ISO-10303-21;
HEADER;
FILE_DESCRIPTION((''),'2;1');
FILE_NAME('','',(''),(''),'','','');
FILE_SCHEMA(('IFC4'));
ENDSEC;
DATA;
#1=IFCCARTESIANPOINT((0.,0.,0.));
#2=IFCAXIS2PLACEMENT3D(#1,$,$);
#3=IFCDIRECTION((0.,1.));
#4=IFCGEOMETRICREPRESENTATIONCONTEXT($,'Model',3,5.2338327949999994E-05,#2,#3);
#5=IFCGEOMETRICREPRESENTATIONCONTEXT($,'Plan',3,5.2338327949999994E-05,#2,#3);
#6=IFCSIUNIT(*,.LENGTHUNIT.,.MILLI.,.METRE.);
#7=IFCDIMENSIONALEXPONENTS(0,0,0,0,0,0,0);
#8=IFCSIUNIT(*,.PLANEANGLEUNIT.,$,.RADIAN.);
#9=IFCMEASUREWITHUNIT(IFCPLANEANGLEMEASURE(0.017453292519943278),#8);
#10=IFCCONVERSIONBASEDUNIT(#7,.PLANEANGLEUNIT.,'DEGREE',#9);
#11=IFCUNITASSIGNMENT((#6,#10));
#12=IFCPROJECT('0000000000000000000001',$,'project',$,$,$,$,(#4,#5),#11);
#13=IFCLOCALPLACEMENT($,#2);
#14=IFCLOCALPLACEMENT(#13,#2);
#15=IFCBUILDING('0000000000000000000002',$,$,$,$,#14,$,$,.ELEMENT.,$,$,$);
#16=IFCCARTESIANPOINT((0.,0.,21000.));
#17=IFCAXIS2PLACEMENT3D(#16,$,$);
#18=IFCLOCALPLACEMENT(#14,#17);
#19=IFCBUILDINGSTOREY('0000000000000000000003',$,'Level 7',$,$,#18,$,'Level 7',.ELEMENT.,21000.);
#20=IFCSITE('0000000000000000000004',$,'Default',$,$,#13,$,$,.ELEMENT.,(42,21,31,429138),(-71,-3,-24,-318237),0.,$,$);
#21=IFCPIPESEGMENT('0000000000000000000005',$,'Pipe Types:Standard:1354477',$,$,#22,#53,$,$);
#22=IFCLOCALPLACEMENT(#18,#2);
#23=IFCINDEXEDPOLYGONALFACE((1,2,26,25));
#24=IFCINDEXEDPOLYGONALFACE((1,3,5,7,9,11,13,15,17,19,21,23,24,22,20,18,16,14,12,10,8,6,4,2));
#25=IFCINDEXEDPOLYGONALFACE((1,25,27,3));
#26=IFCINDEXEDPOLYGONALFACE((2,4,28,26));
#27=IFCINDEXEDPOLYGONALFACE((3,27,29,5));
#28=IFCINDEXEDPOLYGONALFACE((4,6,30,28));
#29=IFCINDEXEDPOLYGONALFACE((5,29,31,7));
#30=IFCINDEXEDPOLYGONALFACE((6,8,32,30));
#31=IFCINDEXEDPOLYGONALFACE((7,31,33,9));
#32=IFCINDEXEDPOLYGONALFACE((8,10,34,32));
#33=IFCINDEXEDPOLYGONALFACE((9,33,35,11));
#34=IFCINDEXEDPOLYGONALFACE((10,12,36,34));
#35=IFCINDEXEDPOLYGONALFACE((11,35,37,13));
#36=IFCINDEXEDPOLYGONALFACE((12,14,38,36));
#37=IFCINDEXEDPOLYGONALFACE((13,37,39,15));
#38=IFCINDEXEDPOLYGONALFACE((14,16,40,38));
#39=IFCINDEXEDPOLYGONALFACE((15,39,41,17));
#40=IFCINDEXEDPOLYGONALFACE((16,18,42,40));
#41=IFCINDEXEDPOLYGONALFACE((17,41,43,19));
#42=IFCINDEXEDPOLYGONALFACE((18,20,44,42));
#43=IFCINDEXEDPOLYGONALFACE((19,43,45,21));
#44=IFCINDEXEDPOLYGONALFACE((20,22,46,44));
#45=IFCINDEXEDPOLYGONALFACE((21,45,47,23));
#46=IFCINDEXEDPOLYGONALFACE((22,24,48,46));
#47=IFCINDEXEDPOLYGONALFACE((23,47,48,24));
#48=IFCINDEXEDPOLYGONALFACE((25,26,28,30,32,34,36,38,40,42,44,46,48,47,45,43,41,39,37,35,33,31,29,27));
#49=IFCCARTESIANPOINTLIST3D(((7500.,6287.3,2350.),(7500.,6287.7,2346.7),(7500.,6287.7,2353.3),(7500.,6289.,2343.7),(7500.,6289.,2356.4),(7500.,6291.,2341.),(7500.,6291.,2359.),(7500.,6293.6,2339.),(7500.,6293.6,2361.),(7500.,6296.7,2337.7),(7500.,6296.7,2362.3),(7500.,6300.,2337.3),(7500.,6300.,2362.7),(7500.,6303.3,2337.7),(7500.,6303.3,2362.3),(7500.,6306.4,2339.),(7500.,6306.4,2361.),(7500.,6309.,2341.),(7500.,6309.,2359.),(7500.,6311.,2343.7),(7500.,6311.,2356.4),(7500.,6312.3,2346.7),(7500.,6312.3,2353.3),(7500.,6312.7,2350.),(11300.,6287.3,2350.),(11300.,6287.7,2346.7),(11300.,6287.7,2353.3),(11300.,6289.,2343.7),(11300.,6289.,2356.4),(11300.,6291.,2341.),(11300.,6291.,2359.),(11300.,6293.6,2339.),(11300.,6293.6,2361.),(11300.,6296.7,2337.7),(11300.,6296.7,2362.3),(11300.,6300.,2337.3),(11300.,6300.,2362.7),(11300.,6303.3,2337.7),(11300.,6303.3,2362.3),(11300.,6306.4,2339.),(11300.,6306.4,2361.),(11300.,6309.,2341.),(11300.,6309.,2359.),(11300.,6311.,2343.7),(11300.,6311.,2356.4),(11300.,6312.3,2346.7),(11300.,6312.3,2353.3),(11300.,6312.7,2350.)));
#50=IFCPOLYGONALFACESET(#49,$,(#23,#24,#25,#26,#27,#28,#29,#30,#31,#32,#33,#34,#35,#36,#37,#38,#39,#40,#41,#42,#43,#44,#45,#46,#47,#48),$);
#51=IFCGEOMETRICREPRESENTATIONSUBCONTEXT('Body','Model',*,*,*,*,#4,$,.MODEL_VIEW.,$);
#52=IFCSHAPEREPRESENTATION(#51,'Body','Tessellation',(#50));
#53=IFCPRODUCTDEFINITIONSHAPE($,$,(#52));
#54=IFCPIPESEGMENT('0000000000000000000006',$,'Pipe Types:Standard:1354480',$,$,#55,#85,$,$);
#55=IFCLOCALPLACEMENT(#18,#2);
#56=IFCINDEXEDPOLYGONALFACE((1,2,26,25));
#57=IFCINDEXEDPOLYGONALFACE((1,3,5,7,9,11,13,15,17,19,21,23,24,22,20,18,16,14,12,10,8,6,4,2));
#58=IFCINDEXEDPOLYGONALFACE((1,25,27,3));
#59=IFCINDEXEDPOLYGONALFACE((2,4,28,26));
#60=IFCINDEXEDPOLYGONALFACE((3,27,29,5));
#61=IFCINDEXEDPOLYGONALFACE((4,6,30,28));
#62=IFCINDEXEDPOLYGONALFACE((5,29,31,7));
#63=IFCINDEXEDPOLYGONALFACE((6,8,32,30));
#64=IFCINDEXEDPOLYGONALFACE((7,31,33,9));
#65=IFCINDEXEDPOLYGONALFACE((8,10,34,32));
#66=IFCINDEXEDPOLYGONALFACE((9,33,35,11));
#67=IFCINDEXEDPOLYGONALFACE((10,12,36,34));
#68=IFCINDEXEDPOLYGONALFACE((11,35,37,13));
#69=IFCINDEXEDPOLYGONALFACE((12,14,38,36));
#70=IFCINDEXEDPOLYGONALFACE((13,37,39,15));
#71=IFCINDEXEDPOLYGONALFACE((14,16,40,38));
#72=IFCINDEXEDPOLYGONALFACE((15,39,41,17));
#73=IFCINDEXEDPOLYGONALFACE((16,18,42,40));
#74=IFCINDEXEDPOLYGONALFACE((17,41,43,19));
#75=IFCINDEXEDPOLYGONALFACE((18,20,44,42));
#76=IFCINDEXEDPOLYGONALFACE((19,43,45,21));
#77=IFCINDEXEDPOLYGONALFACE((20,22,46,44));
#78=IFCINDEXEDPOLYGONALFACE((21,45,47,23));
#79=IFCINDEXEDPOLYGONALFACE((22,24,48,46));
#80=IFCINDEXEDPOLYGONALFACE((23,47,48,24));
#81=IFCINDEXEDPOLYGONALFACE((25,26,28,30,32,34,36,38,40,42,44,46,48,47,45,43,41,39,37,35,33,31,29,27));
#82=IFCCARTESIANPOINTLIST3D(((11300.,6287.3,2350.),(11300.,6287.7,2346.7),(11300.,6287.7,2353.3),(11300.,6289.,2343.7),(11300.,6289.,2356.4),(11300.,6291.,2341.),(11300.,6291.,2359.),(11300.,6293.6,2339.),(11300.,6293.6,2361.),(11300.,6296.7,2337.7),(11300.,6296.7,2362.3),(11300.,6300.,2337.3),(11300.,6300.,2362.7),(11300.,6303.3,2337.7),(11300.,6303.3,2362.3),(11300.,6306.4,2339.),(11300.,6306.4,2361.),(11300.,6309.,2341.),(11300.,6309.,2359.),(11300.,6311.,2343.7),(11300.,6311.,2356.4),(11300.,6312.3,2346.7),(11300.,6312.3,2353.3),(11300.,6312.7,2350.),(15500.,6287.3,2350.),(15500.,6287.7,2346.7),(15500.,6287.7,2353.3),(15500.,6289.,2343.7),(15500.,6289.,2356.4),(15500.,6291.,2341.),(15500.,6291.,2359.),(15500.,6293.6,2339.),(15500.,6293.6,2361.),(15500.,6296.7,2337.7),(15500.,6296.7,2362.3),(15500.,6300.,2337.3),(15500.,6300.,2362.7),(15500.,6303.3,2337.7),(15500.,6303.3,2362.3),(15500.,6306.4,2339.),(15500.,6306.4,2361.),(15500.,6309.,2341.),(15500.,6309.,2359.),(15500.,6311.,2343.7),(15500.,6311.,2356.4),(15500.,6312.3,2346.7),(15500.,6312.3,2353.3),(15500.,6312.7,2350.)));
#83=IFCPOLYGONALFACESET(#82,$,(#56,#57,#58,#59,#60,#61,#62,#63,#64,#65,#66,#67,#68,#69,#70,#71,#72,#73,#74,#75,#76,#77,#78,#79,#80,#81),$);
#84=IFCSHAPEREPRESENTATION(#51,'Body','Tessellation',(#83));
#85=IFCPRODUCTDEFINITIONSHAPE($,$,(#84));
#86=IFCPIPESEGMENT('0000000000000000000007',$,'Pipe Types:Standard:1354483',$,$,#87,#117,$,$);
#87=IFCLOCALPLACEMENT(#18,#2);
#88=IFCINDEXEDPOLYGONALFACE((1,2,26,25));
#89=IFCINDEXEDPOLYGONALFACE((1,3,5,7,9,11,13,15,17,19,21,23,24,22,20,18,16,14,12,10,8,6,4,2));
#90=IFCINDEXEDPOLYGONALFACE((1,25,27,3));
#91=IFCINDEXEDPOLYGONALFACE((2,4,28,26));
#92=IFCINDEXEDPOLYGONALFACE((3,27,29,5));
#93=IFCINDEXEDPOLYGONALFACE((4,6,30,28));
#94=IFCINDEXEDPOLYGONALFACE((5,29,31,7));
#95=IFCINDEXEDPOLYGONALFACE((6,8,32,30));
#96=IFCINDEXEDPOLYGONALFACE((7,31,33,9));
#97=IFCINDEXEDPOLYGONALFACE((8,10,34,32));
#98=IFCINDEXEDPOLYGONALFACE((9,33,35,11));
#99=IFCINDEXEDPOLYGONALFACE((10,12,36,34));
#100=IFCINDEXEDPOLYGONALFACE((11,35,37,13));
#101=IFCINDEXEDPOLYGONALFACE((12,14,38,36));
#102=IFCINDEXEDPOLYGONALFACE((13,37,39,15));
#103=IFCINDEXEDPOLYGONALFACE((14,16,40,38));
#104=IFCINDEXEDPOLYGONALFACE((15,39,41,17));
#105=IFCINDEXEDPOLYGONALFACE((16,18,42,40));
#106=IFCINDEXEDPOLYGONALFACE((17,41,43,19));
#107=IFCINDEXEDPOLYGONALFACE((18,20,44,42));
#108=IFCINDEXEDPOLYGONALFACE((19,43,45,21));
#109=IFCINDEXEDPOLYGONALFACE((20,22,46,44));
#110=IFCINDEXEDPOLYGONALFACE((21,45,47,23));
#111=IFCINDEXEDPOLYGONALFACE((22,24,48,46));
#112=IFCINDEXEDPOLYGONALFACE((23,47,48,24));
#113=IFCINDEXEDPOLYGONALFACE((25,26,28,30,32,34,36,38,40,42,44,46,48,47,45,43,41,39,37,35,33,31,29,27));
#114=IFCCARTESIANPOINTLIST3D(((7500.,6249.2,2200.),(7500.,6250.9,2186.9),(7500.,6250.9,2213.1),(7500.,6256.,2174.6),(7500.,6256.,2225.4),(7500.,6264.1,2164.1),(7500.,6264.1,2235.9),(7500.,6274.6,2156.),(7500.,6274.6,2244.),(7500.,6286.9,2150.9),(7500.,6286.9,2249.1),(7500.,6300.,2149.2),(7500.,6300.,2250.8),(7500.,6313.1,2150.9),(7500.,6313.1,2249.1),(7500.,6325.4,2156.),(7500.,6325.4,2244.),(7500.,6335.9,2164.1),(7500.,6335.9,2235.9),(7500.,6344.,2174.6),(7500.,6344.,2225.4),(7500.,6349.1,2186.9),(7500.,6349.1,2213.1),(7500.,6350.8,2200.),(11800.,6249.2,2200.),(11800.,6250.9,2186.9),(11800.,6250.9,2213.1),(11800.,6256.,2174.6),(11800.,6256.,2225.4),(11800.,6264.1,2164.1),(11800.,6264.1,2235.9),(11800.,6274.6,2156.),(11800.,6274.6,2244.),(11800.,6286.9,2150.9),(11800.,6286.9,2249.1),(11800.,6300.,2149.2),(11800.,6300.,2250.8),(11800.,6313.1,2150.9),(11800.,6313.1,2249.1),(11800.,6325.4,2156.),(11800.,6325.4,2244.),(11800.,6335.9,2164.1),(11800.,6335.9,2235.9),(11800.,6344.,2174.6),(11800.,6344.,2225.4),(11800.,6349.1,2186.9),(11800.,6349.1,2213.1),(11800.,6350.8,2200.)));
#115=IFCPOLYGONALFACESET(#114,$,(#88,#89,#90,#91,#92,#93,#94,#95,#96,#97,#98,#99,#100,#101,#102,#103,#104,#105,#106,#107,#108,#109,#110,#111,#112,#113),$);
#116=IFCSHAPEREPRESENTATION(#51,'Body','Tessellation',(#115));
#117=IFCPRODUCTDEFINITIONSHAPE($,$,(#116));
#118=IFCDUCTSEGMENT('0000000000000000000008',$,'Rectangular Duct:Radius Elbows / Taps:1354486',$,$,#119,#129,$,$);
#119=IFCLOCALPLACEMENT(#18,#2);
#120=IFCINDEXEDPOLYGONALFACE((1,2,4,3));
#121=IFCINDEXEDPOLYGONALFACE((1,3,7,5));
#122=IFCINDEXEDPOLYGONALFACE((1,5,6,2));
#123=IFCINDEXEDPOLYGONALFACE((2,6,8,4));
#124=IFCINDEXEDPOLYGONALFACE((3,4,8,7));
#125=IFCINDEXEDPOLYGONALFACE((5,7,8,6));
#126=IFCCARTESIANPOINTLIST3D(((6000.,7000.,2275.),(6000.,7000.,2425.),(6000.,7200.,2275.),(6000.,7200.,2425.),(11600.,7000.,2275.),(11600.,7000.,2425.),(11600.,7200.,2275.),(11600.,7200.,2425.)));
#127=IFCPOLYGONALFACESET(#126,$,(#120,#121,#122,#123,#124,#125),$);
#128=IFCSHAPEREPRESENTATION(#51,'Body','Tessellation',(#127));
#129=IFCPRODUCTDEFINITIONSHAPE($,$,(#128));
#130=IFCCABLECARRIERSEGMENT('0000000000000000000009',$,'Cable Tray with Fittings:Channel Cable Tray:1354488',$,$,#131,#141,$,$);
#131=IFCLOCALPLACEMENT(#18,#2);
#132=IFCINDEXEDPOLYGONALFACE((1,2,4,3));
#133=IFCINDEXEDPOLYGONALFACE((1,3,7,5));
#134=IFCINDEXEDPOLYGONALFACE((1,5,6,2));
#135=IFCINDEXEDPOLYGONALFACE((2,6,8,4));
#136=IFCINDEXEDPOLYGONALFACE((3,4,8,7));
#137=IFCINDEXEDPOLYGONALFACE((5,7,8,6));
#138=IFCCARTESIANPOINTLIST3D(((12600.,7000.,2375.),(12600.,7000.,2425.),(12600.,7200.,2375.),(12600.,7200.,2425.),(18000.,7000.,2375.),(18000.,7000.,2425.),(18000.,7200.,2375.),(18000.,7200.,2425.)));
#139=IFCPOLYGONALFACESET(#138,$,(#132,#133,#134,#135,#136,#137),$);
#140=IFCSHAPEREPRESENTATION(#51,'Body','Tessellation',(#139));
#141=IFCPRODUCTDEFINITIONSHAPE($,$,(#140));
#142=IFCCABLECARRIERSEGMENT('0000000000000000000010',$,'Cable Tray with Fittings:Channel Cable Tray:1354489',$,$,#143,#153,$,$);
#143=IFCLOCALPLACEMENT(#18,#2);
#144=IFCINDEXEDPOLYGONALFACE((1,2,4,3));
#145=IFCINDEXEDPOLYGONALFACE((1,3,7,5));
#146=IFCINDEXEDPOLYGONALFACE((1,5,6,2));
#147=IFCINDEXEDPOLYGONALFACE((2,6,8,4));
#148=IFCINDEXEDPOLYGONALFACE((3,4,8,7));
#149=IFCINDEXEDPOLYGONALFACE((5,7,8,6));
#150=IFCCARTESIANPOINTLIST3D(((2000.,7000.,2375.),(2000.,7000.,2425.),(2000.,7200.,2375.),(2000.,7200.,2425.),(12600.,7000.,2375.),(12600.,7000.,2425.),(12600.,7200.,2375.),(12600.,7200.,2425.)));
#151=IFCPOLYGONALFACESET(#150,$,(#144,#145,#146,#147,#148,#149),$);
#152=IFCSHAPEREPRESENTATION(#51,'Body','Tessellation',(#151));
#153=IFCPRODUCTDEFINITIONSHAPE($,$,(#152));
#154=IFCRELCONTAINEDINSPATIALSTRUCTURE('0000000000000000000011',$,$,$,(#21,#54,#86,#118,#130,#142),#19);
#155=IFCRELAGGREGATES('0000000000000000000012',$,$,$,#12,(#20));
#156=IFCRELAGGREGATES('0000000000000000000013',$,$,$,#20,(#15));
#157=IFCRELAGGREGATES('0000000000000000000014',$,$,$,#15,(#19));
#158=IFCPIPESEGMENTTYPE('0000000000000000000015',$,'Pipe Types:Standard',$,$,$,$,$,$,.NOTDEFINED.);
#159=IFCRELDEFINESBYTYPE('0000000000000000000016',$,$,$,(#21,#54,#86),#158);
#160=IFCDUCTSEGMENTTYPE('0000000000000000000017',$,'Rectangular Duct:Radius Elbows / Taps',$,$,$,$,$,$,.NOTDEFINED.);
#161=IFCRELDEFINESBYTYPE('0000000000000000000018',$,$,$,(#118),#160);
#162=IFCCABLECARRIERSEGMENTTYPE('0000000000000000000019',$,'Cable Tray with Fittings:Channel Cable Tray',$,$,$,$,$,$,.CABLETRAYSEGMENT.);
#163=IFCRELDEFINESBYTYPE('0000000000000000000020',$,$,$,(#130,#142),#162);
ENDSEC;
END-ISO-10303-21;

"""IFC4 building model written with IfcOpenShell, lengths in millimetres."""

from ifc_helpers import new_model, entity, si_unit, converted_unit, direction, frame, origin, place, context, subcontext, project, spatial, arc, indexed_curve, outline, extrude, type_object, element, save


model = new_model("IFC4")

# Units and contexts
model_context = context("Model", 3, precision=5.2338327949999994e-05, world=origin(), true_north=direction((0.0, 1.0)))
plan_context = context("Plan", 3, precision=5.2338327949999994e-05, world=origin(), true_north=direction((0.0, 1.0)))
body_context = subcontext(model_context, "Body", "Model", "MODEL_VIEW")
ifc_project = project(units=[si_unit("LENGTHUNIT", "METRE", prefix="MILLI"), converted_unit("PLANEANGLEUNIT", "DEGREE", entity("IfcPlaneAngleMeasure", 0.017453292519943278), si_unit("PLANEANGLEUNIT", "RADIAN"), dimensions=[0, 0, 0, 0, 0, 0, 0])], contexts=[model_context, plan_context])

# Site, building, storey
site_placement = place(None, origin())
site = spatial("IfcSite", under=ifc_project, at=site_placement, Name="Default", CompositionType="ELEMENT", RefLatitude=(42, 21, 31, 429138), RefLongitude=(-71, -3, -24, -318237), RefElevation=0.0)
building_placement = place(site_placement, origin())
building = spatial("IfcBuilding", under=site, at=building_placement, CompositionType="ELEMENT")
storey_placement = place(building_placement, frame((0.0, 0.0, 21000.0)))
storey = spatial("IfcBuildingStorey", under=building, at=storey_placement, Name="Level 7", LongName="Level 7", CompositionType="ELEMENT", Elevation=21000.0)

# Pipe segments
pipe_segment_type = type_object("IfcPipeSegmentType", Name="Pipe Types:Standard", PredefinedType="NOTDEFINED")
pipe_segment_1_placement = place(storey_placement, origin())
element("IfcPipeSegment", 1, at=pipe_segment_1_placement, inside=storey, type_object=pipe_segment_type, Name="Pipe Types:Standard:1354477", context=body_context, shape_type="SweptSolid", body=[
    extrude(outline(indexed_curve([(12.7, 0.0), (9.0, 9.0), (0.0, 12.7), (-9.0, 9.0), (-12.7, 0.0), (-9.0, -9.0), (0.0, -12.7), (9.0, -9.0)], segments=[arc(1, 2, 3), arc(3, 4, 5), arc(5, 6, 7), arc(7, 8, 1)], self_intersect=False)), frame((7500.0, 6300.0, 2350.0), z_axis=(1.0, 0.0, 0.0), x_axis=(0.0, 1.0, 0.0)), (0.0, 0.0, 1.0), 3800.0),
])
pipe_segment_2_placement = place(storey_placement, origin())
element("IfcPipeSegment", 2, at=pipe_segment_2_placement, inside=storey, type_object=pipe_segment_type, Name="Pipe Types:Standard:1354480", context=body_context, shape_type="SweptSolid", body=[
    extrude(outline(indexed_curve([(12.7, 0.0), (9.0, 9.0), (0.0, 12.7), (-9.0, 9.0), (-12.7, 0.0), (-9.0, -9.0), (0.0, -12.7), (9.0, -9.0)], segments=[arc(1, 2, 3), arc(3, 4, 5), arc(5, 6, 7), arc(7, 8, 1)], self_intersect=False)), frame((11300.0, 6300.0, 2350.0), z_axis=(1.0, 0.0, 0.0), x_axis=(0.0, -1.0, 0.0)), (0.0, 0.0, 1.0), 4200.0),
])
pipe_segment_3_placement = place(storey_placement, origin())
element("IfcPipeSegment", 3, at=pipe_segment_3_placement, inside=storey, type_object=pipe_segment_type, Name="Pipe Types:Standard:1354483", context=body_context, shape_type="SweptSolid", body=[
    extrude(outline(indexed_curve([(50.8, 0.0), (35.9, 35.9), (0.0, 50.8), (-35.9, 35.9), (-50.8, 0.0), (-35.9, -35.9), (0.0, -50.8), (35.9, -35.9)], segments=[arc(1, 2, 3), arc(3, 4, 5), arc(5, 6, 7), arc(7, 8, 1)], self_intersect=False)), frame((7500.0, 6300.0, 2200.0), z_axis=(1.0, 0.0, 0.0), x_axis=(0.0, 1.0, 0.0)), (0.0, 0.0, 1.0), 4300.0),
])

# Duct segment
duct_segment_type = type_object("IfcDuctSegmentType", Name="Rectangular Duct:Radius Elbows / Taps", PredefinedType="NOTDEFINED")
duct_segment_placement = place(storey_placement, origin())
element("IfcDuctSegment", 4, at=duct_segment_placement, inside=storey, type_object=duct_segment_type, Name="Rectangular Duct:Radius Elbows / Taps:1354486", context=body_context, shape_type="SweptSolid", body=[
    extrude(outline(indexed_curve([(-2800.0, -100.0), (2800.0, -100.0), (2800.0, 100.0), (-2800.0, 100.0), (-2800.0, -100.0)], self_intersect=False)), frame((8800.0, 7100.0, 2275.0), z_axis=(0.0, 0.0, 1.0), x_axis=(-1.0, 0.0, 0.0)), (0.0, 0.0, 1.0), 150.0),
])

# Cable carrier segments
cable_carrier_segment_type = type_object("IfcCableCarrierSegmentType", Name="Cable Tray with Fittings:Channel Cable Tray", PredefinedType="CABLETRAYSEGMENT")
cable_carrier_segment_1_placement = place(storey_placement, origin())
element("IfcCableCarrierSegment", 5, at=cable_carrier_segment_1_placement, inside=storey, type_object=cable_carrier_segment_type, Name="Cable Tray with Fittings:Channel Cable Tray:1354488", context=body_context, shape_type="SweptSolid", body=[
    extrude(outline(indexed_curve([(-2700.0, -100.0), (2700.0, -100.0), (2700.0, 100.0), (-2700.0, 100.0), (-2700.0, -100.0)], self_intersect=False)), frame((15300.0, 7100.0, 2375.0)), (0.0, 0.0, 1.0), 50.0),
])
cable_carrier_segment_2_placement = place(storey_placement, origin())
element("IfcCableCarrierSegment", 6, at=cable_carrier_segment_2_placement, inside=storey, type_object=cable_carrier_segment_type, Name="Cable Tray with Fittings:Channel Cable Tray:1354489", context=body_context, shape_type="SweptSolid", body=[
    extrude(outline(indexed_curve([(-5300.0, -100.0), (5300.0, -100.0), (5300.0, 100.0), (-5300.0, 100.0), (-5300.0, -100.0)], self_intersect=False)), frame((7300.0, 7100.0, 2375.0), z_axis=(0.0, 0.0, 1.0), x_axis=(-1.0, 0.0, 0.0)), (0.0, 0.0, 1.0), 50.0),
])

save(model, "model.ifc")
